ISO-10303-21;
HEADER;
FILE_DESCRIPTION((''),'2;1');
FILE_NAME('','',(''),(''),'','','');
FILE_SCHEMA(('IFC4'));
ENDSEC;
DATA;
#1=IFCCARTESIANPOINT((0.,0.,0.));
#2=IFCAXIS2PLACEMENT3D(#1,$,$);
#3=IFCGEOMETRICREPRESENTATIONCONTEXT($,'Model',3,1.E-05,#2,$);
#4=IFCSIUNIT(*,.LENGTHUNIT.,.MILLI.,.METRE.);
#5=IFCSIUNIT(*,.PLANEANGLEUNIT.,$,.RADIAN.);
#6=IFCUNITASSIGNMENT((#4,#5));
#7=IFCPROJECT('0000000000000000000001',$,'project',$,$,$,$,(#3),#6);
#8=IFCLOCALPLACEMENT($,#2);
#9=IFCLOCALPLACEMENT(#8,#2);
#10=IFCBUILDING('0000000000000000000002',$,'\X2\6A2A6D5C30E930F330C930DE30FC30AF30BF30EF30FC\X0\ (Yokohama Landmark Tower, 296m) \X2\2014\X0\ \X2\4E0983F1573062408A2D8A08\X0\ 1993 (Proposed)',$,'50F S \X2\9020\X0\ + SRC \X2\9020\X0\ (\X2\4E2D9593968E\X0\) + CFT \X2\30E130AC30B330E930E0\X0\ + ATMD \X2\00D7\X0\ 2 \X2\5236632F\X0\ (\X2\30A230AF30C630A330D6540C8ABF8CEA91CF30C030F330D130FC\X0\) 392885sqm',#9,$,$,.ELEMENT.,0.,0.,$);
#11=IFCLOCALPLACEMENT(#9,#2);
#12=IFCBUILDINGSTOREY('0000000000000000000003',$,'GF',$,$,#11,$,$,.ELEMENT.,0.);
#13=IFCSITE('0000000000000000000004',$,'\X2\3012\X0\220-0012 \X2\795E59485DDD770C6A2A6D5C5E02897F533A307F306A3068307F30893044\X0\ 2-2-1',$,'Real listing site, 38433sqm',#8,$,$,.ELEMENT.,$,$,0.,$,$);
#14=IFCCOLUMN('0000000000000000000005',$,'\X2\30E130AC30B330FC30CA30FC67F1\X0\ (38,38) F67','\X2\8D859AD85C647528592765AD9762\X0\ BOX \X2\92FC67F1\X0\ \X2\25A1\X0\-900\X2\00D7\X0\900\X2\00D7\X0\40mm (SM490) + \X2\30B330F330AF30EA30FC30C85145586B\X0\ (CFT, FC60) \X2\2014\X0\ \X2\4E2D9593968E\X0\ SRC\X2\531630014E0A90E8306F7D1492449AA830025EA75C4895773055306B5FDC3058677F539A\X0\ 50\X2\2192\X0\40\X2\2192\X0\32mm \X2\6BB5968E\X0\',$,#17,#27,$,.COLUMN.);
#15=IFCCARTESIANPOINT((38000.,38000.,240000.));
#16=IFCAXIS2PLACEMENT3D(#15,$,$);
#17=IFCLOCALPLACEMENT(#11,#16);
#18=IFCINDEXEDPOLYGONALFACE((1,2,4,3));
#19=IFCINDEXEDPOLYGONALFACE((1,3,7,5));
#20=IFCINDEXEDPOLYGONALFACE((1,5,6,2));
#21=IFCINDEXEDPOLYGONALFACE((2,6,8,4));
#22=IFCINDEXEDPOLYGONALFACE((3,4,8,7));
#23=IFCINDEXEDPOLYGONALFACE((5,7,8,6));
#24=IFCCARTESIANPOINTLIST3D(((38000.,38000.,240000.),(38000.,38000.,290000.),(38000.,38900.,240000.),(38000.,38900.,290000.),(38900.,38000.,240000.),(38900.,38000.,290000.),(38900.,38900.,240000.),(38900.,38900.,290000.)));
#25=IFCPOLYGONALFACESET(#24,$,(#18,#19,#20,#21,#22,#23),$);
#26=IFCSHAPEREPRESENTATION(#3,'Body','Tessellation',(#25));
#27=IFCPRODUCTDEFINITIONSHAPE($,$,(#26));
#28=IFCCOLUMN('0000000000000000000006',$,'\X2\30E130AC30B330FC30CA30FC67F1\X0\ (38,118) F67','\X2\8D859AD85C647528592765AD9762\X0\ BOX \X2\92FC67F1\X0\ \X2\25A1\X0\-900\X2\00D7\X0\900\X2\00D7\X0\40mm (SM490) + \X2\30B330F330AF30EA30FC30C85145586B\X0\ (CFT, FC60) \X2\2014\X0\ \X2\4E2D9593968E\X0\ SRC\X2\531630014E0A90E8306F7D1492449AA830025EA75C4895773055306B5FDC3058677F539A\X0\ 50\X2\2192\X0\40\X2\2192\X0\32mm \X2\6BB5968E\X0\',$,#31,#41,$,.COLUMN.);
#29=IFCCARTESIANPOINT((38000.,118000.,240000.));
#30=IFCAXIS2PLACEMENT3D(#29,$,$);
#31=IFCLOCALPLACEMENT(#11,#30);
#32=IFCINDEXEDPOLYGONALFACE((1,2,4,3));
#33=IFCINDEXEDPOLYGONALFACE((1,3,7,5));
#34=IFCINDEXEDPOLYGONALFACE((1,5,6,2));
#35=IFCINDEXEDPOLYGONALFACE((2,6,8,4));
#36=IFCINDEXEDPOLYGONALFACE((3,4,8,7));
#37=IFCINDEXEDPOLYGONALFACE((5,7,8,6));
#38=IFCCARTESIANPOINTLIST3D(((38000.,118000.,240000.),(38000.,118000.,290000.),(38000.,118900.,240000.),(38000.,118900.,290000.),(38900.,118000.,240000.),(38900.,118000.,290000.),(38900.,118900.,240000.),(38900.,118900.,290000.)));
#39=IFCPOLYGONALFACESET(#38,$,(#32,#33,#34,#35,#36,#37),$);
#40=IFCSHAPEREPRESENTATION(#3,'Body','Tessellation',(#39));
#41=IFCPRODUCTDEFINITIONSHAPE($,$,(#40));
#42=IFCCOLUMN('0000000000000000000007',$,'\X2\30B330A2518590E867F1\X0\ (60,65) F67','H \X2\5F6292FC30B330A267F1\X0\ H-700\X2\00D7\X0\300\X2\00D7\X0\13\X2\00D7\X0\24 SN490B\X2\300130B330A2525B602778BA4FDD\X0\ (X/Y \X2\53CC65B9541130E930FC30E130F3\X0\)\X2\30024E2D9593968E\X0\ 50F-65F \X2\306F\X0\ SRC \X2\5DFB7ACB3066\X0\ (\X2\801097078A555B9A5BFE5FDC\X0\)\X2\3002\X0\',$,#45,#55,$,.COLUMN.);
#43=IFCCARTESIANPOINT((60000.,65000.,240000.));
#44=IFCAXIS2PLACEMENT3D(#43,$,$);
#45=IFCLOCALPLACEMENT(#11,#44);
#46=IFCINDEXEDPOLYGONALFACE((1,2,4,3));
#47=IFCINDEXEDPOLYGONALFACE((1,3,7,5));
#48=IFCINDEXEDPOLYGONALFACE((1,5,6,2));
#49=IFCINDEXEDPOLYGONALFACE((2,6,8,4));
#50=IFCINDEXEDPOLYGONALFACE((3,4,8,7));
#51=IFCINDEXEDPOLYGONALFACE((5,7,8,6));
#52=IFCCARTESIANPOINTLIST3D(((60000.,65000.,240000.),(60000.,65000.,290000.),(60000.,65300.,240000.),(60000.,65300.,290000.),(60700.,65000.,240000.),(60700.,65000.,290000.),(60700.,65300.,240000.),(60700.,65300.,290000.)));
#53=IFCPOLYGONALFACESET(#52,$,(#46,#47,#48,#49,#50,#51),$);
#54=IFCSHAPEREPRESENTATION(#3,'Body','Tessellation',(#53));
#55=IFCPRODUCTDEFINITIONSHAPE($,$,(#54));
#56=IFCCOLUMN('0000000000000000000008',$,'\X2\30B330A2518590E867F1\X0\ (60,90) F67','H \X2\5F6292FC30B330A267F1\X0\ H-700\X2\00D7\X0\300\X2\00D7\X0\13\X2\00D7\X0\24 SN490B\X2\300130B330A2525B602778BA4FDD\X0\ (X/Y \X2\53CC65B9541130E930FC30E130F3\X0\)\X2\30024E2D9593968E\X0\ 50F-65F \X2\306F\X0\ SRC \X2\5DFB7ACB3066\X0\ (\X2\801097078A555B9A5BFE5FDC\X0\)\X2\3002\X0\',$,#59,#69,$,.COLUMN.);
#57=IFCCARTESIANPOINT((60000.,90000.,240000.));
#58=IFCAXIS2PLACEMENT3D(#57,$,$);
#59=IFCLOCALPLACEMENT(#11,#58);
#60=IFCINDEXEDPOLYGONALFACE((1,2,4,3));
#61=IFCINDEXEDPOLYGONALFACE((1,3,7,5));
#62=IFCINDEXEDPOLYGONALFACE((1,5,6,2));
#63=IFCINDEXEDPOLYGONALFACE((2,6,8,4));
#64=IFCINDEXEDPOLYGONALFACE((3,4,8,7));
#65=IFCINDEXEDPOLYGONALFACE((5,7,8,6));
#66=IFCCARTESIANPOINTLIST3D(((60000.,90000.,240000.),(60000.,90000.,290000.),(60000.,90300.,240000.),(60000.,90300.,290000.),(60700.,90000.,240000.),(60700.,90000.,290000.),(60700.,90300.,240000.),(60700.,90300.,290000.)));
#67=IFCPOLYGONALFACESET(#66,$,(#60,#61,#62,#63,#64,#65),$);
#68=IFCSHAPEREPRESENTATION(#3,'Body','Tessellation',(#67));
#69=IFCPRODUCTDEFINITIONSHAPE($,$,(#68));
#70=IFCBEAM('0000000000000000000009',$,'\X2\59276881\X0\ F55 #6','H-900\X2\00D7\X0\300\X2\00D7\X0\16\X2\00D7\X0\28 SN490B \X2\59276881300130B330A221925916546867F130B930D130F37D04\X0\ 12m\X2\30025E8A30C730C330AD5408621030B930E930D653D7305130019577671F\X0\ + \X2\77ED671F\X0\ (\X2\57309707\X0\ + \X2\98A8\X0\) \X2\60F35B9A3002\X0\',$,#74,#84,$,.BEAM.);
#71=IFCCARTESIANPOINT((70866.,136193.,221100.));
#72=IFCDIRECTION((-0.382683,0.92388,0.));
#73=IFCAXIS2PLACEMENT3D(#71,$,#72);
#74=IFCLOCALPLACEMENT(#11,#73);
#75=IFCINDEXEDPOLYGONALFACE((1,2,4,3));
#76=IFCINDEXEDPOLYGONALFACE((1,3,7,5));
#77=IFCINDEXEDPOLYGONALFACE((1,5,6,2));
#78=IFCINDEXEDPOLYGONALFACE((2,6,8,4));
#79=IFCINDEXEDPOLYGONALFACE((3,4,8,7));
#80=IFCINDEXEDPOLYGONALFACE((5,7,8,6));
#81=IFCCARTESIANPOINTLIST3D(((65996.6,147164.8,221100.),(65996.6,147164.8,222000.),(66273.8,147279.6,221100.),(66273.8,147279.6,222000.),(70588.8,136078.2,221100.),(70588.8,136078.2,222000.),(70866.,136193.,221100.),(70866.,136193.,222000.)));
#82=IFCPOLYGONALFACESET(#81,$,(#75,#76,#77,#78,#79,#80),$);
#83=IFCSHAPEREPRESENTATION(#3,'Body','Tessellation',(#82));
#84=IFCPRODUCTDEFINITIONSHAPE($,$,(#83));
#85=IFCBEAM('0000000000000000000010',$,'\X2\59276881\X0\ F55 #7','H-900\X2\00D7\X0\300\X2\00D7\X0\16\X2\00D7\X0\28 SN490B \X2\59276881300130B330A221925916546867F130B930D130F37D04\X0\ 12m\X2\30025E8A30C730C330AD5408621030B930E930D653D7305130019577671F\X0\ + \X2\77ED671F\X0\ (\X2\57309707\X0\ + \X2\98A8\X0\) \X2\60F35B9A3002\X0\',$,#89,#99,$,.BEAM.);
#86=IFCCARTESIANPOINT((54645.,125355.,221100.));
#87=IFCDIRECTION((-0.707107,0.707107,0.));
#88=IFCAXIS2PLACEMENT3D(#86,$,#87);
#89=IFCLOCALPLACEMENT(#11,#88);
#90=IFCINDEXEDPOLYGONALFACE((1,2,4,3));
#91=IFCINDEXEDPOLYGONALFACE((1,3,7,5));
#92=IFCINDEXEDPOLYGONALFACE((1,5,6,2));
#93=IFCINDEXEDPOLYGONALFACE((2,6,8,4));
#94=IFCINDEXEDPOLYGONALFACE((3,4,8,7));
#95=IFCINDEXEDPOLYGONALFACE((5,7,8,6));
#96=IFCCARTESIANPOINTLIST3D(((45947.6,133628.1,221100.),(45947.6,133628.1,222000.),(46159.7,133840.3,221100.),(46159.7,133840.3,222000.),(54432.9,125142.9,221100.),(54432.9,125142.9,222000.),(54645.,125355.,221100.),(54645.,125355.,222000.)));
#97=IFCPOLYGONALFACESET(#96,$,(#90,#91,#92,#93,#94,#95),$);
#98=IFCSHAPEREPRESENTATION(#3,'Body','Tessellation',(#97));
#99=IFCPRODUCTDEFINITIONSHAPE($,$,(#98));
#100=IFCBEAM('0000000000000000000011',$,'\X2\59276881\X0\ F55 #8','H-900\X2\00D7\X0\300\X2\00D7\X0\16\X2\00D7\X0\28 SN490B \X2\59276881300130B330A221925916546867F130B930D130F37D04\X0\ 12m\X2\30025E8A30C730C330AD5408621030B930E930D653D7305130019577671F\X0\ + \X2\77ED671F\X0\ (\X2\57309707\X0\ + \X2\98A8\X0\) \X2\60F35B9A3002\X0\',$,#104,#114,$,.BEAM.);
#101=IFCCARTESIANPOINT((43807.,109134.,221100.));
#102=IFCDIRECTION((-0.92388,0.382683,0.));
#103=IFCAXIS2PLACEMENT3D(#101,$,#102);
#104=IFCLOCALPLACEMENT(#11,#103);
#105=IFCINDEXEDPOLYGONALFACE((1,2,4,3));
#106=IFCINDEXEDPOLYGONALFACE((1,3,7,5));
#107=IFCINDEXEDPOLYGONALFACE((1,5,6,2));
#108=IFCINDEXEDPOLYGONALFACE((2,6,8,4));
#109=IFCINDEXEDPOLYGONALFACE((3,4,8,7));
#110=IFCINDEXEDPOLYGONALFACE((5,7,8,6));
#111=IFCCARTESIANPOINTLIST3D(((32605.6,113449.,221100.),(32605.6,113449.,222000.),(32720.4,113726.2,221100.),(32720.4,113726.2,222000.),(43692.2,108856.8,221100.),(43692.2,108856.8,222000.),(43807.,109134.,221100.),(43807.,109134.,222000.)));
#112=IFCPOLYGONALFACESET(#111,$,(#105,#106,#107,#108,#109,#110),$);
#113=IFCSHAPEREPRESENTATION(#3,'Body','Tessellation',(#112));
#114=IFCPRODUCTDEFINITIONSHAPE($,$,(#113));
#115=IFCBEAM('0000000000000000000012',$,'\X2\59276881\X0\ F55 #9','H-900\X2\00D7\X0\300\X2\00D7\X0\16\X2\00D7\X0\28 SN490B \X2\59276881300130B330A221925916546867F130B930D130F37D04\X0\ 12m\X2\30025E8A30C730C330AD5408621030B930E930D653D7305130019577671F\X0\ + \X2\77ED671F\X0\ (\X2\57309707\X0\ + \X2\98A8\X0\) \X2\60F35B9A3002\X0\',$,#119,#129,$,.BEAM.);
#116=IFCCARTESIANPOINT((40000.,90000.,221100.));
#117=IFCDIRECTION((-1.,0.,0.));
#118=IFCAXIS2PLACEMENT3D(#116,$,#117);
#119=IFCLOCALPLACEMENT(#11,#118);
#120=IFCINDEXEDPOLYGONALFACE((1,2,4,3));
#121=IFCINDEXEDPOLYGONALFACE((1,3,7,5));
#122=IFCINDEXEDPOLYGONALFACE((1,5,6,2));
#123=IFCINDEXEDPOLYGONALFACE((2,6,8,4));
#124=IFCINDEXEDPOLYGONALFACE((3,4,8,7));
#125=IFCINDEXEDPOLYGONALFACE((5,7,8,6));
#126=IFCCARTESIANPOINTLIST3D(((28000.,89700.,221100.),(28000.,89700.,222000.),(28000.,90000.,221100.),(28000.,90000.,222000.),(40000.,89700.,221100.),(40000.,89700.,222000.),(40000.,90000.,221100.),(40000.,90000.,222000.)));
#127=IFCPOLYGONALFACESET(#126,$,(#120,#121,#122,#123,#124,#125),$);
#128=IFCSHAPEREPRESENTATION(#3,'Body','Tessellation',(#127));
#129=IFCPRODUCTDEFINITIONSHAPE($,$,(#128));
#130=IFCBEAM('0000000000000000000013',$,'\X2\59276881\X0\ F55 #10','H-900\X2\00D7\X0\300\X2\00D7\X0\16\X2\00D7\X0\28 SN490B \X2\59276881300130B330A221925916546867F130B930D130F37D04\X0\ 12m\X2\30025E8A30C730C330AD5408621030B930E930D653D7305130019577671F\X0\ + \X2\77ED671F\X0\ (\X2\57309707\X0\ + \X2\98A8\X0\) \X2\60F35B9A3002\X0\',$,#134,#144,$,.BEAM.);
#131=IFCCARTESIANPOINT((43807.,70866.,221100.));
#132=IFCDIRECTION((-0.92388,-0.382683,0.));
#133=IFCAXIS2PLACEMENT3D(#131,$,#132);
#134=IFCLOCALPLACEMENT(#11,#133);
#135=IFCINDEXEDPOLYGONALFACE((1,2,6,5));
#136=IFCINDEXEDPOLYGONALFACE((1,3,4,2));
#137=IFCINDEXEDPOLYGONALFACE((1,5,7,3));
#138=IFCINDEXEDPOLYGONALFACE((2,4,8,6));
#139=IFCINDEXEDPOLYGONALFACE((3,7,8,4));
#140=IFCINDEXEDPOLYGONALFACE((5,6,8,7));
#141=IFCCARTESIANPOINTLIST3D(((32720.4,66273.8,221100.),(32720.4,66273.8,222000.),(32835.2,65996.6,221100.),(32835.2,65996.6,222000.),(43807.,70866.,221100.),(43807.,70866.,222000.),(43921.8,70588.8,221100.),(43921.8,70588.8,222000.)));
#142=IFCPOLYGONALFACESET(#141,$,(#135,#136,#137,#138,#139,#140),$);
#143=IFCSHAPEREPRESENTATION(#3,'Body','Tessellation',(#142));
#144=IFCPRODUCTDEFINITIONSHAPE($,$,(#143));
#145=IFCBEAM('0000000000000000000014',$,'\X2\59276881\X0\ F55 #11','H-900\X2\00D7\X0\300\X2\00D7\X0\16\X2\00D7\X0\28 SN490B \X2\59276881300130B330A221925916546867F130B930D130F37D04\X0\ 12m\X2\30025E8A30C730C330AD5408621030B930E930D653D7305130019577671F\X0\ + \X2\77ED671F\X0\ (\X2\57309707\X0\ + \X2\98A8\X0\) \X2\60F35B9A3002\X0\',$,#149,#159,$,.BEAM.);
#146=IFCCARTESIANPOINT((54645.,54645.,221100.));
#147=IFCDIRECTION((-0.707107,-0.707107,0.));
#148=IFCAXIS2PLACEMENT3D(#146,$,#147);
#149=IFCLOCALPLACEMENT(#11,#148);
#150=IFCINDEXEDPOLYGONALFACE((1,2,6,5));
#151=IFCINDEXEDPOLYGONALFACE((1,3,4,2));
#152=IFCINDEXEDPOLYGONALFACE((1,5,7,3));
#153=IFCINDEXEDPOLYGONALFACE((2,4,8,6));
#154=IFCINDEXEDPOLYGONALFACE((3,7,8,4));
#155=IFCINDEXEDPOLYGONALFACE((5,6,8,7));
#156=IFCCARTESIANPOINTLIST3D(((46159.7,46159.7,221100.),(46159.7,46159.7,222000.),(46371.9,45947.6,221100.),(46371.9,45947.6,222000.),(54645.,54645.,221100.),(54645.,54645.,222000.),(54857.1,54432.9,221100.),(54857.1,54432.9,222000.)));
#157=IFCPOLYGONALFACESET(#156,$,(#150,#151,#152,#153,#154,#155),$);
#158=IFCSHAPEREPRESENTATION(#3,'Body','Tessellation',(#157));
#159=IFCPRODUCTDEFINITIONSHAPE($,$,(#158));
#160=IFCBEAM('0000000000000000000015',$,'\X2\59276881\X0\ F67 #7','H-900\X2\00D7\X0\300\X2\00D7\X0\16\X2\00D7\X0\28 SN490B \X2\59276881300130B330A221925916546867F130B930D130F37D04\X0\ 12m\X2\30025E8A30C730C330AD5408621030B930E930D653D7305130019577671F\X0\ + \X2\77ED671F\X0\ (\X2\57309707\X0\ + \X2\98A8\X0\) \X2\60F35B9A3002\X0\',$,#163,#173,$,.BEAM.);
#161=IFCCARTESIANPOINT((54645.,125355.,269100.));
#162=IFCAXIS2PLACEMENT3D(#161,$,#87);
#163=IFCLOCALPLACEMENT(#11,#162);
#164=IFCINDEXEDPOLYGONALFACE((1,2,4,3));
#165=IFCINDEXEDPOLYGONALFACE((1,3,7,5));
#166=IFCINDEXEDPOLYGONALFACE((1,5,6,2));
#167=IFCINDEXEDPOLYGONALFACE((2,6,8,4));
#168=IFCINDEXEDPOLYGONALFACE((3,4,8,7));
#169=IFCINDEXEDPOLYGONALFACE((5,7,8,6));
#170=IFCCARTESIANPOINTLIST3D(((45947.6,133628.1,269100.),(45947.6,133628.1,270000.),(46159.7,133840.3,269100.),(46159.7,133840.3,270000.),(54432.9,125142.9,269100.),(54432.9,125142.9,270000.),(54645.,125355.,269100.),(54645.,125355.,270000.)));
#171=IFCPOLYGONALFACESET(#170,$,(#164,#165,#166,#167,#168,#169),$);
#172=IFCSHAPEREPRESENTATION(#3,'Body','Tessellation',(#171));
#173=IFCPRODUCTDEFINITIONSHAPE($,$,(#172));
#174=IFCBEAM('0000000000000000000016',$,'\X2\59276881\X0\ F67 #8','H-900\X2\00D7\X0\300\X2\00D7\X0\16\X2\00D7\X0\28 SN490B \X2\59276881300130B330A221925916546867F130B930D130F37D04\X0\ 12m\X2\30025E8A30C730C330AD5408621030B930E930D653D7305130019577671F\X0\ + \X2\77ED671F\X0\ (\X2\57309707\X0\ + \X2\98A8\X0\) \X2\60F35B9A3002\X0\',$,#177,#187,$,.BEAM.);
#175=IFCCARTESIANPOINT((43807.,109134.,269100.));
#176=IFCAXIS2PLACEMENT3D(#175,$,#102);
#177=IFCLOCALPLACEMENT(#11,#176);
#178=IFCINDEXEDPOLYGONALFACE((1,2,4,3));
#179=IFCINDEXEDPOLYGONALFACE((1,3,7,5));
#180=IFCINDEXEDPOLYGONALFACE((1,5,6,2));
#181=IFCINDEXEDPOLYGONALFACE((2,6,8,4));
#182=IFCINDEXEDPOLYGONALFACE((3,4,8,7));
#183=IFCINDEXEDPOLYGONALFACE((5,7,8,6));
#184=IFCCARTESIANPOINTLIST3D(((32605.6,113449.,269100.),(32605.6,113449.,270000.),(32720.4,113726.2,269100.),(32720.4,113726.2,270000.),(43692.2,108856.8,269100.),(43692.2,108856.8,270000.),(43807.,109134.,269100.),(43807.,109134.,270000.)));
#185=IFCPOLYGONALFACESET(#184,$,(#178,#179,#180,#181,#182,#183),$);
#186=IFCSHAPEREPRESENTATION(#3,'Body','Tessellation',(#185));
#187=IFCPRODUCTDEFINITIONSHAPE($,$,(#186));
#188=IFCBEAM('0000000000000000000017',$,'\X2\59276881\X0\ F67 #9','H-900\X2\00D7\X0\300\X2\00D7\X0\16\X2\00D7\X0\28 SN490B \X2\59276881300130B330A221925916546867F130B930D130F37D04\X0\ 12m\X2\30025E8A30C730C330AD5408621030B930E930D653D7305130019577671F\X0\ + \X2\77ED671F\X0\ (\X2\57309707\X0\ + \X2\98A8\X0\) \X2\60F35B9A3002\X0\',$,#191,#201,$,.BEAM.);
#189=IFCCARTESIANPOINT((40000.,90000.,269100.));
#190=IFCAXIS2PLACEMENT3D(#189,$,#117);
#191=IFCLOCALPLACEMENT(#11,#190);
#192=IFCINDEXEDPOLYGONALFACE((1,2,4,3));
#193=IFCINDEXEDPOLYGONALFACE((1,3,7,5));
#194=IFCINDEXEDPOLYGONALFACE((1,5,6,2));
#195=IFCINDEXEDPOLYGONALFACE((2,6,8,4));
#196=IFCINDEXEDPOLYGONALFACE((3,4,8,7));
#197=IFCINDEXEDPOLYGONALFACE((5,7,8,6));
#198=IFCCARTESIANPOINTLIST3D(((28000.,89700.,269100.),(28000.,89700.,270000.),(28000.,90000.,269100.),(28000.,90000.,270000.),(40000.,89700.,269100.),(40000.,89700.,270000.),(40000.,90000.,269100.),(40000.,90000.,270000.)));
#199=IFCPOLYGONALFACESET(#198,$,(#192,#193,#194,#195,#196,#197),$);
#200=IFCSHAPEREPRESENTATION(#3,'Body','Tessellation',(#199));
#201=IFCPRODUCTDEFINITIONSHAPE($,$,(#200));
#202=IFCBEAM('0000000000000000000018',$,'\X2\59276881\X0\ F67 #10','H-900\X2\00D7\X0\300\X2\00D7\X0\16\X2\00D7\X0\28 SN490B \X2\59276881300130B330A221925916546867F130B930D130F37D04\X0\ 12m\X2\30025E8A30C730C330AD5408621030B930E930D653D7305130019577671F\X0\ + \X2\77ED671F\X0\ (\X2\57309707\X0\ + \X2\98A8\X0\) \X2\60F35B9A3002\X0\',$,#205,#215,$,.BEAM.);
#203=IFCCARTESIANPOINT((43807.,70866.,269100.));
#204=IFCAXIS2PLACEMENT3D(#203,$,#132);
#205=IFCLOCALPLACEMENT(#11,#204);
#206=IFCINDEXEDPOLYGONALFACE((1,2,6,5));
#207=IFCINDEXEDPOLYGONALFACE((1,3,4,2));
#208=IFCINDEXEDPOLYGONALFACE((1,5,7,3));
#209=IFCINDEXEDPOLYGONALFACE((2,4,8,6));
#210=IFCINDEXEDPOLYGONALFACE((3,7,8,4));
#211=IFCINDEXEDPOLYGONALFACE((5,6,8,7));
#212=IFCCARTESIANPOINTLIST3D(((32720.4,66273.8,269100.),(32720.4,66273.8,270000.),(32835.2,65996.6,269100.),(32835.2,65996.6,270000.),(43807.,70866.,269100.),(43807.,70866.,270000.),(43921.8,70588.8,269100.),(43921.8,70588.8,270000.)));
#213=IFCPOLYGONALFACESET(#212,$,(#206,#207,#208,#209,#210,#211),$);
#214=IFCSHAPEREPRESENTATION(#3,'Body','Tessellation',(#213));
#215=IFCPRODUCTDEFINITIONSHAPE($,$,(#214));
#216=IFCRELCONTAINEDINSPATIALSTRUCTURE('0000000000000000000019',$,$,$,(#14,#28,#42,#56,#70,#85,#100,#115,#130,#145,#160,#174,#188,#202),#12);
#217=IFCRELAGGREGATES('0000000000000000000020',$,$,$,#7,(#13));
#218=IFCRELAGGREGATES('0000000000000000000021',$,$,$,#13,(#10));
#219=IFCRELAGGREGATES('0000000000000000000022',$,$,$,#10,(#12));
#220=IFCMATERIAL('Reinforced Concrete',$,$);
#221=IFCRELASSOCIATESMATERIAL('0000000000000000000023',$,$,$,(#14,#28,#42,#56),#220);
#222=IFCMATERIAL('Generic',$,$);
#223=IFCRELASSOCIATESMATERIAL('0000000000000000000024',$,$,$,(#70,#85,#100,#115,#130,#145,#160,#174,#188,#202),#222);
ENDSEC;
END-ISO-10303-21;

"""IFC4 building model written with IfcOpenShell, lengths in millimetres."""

from ifc_helpers import new_model, si_unit, frame, frame_2d, origin, place, context, project, spatial, rectangle, extrude, material, element, save


model = new_model("IFC4")

# Units and contexts
model_context = context("Model", 3, precision=1e-05, world=origin())
ifc_project = project(units=[si_unit("LENGTHUNIT", "METRE", prefix="MILLI"), si_unit("PLANEANGLEUNIT", "RADIAN")], contexts=[model_context])

# Site, building, storey
site_placement = place(None, origin())
site = spatial("IfcSite", under=ifc_project, at=site_placement, Name="〒220-0012 神奈川県横浜市西区みなとみらい 2-2-1", ObjectType="Real listing site, 38433sqm", CompositionType="ELEMENT", RefElevation=0.0)
building_placement = place(site_placement, origin())
building = spatial("IfcBuilding", under=site, at=building_placement, Name="横浜ランドマークタワー (Yokohama Landmark Tower, 296m) — 三菱地所設計 1993 (Proposed)", ObjectType="50F S 造 + SRC 造 (中間階) + CFT メガコラム + ATMD × 2 制振 (アクティブ同調質量ダンパー) 392885sqm", CompositionType="ELEMENT", ElevationOfRefHeight=0.0, ElevationOfTerrain=0.0)
storey_placement = place(building_placement, origin())
storey = spatial("IfcBuildingStorey", under=building, at=storey_placement, Name="GF", CompositionType="ELEMENT", Elevation=0.0)

# Columns
ifc_material_1 = material(Name="Reinforced Concrete")
column_1_placement = place(storey_placement, frame((38000.0, 38000.0, 240000.0)))
element("IfcColumn", 1, at=column_1_placement, inside=storey, material=ifc_material_1, Name="メガコーナー柱 (38,38) F67", Description="超高層用大断面 BOX 鋼柱 □-900×900×40mm (SM490) + コンクリート充填 (CFT, FC60) — 中間階 SRC化、上部は純鉄骨。座屈長さに応じ板厚 50→40→32mm 段階", PredefinedType="COLUMN", context=model_context, shape_type="SweptSolid", body=[
    extrude(rectangle(XDim=900.0, YDim=900.0, at=frame_2d((450.0, 450.0))), frame((38000.0, 38000.0, 240000.0)), (0.0, 0.0, 1.0), 50000.0),
])
column_2_placement = place(storey_placement, frame((38000.0, 118000.0, 240000.0)))
element("IfcColumn", 2, at=column_2_placement, inside=storey, material=ifc_material_1, Name="メガコーナー柱 (38,118) F67", Description="超高層用大断面 BOX 鋼柱 □-900×900×40mm (SM490) + コンクリート充填 (CFT, FC60) — 中間階 SRC化、上部は純鉄骨。座屈長さに応じ板厚 50→40→32mm 段階", PredefinedType="COLUMN", context=model_context, shape_type="SweptSolid", body=[
    extrude(rectangle(XDim=900.0, YDim=900.0, at=frame_2d((450.0, 450.0))), frame((38000.0, 118000.0, 240000.0)), (0.0, 0.0, 1.0), 50000.0),
])
column_3_placement = place(storey_placement, frame((60000.0, 65000.0, 240000.0)))
element("IfcColumn", 3, at=column_3_placement, inside=storey, material=ifc_material_1, Name="コア内部柱 (60,65) F67", Description="H 形鋼コア柱 H-700×300×13×24 SN490B、コア剛性確保 (X/Y 双方向ラーメン)。中間階 50F-65F は SRC 巻立て (耐震評定対応)。", PredefinedType="COLUMN", context=model_context, shape_type="SweptSolid", body=[
    extrude(rectangle(XDim=700.0, YDim=300.0, at=frame_2d((350.0, 150.0))), frame((60000.0, 65000.0, 240000.0)), (0.0, 0.0, 1.0), 50000.0),
])
column_4_placement = place(storey_placement, frame((60000.0, 90000.0, 240000.0)))
element("IfcColumn", 4, at=column_4_placement, inside=storey, material=ifc_material_1, Name="コア内部柱 (60,90) F67", Description="H 形鋼コア柱 H-700×300×13×24 SN490B、コア剛性確保 (X/Y 双方向ラーメン)。中間階 50F-65F は SRC 巻立て (耐震評定対応)。", PredefinedType="COLUMN", context=model_context, shape_type="SweptSolid", body=[
    extrude(rectangle(XDim=700.0, YDim=300.0, at=frame_2d((350.0, 150.0))), frame((60000.0, 90000.0, 240000.0)), (0.0, 0.0, 1.0), 50000.0),
])

# Beams
ifc_material_2 = material(Name="Generic")
beam_1_placement = place(storey_placement, frame((70866.0, 136193.0, 221100.0), x_axis=(-0.382683, 0.92388, 0.0)))
element("IfcBeam", 5, at=beam_1_placement, inside=storey, material=ifc_material_2, Name="大梁 F55 #6", Description="H-900×300×16×28 SN490B 大梁、コア→外周柱スパン約 12m。床デッキ合成スラブ受け、長期 + 短期 (地震 + 風) 想定。", PredefinedType="BEAM", context=model_context, shape_type="SweptSolid", body=[
    extrude(rectangle(XDim=12000.0, YDim=300.0, at=frame_2d((6000.0, 150.0))), frame((70866.0, 136193.0, 221100.0), x_axis=(-0.382683, 0.92388, 0.0)), (0.0, 0.0, 1.0), 900.0),
])
beam_2_placement = place(storey_placement, frame((54645.0, 125355.0, 221100.0), x_axis=(-0.707107, 0.707107, 0.0)))
element("IfcBeam", 6, at=beam_2_placement, inside=storey, material=ifc_material_2, Name="大梁 F55 #7", Description="H-900×300×16×28 SN490B 大梁、コア→外周柱スパン約 12m。床デッキ合成スラブ受け、長期 + 短期 (地震 + 風) 想定。", PredefinedType="BEAM", context=model_context, shape_type="SweptSolid", body=[
    extrude(rectangle(XDim=12000.0, YDim=300.0, at=frame_2d((6000.0, 150.0))), frame((54645.0, 125355.0, 221100.0), x_axis=(-0.707107, 0.707107, 0.0)), (0.0, 0.0, 1.0), 900.0),
])
beam_3_placement = place(storey_placement, frame((43807.0, 109134.0, 221100.0), x_axis=(-0.92388, 0.382683, 0.0)))
element("IfcBeam", 7, at=beam_3_placement, inside=storey, material=ifc_material_2, Name="大梁 F55 #8", Description="H-900×300×16×28 SN490B 大梁、コア→外周柱スパン約 12m。床デッキ合成スラブ受け、長期 + 短期 (地震 + 風) 想定。", PredefinedType="BEAM", context=model_context, shape_type="SweptSolid", body=[
    extrude(rectangle(XDim=12000.0, YDim=300.0, at=frame_2d((6000.0, 150.0))), frame((43807.0, 109134.0, 221100.0), x_axis=(-0.92388, 0.382683, 0.0)), (0.0, 0.0, 1.0), 900.0),
])
beam_4_placement = place(storey_placement, frame((40000.0, 90000.0, 221100.0), x_axis=(-1.0, 0.0, 0.0)))
element("IfcBeam", 8, at=beam_4_placement, inside=storey, material=ifc_material_2, Name="大梁 F55 #9", Description="H-900×300×16×28 SN490B 大梁、コア→外周柱スパン約 12m。床デッキ合成スラブ受け、長期 + 短期 (地震 + 風) 想定。", PredefinedType="BEAM", context=model_context, shape_type="SweptSolid", body=[
    extrude(rectangle(XDim=12000.0, YDim=300.0, at=frame_2d((6000.0, 150.0))), frame((40000.0, 90000.0, 221100.0), x_axis=(-1.0, 0.0, 0.0)), (0.0, 0.0, 1.0), 900.0),
])
beam_5_placement = place(storey_placement, frame((43807.0, 70866.0, 221100.0), x_axis=(-0.92388, -0.382683, 0.0)))
element("IfcBeam", 9, at=beam_5_placement, inside=storey, material=ifc_material_2, Name="大梁 F55 #10", Description="H-900×300×16×28 SN490B 大梁、コア→外周柱スパン約 12m。床デッキ合成スラブ受け、長期 + 短期 (地震 + 風) 想定。", PredefinedType="BEAM", context=model_context, shape_type="SweptSolid", body=[
    extrude(rectangle(XDim=12000.0, YDim=300.0, at=frame_2d((6000.0, 150.0))), frame((43807.0, 70866.0, 221100.0), x_axis=(-0.92388, -0.382683, 0.0)), (0.0, 0.0, 1.0), 900.0),
])
beam_6_placement = place(storey_placement, frame((54645.0, 54645.0, 221100.0), x_axis=(-0.707107, -0.707107, 0.0)))
element("IfcBeam", 10, at=beam_6_placement, inside=storey, material=ifc_material_2, Name="大梁 F55 #11", Description="H-900×300×16×28 SN490B 大梁、コア→外周柱スパン約 12m。床デッキ合成スラブ受け、長期 + 短期 (地震 + 風) 想定。", PredefinedType="BEAM", context=model_context, shape_type="SweptSolid", body=[
    extrude(rectangle(XDim=12000.0, YDim=300.0, at=frame_2d((6000.0, 150.0))), frame((54645.0, 54645.0, 221100.0), x_axis=(-0.707107, -0.707107, 0.0)), (0.0, 0.0, 1.0), 900.0),
])
beam_7_placement = place(storey_placement, frame((54645.0, 125355.0, 269100.0), x_axis=(-0.707107, 0.707107, 0.0)))
element("IfcBeam", 11, at=beam_7_placement, inside=storey, material=ifc_material_2, Name="大梁 F67 #7", Description="H-900×300×16×28 SN490B 大梁、コア→外周柱スパン約 12m。床デッキ合成スラブ受け、長期 + 短期 (地震 + 風) 想定。", PredefinedType="BEAM", context=model_context, shape_type="SweptSolid", body=[
    extrude(rectangle(XDim=12000.0, YDim=300.0, at=frame_2d((6000.0, 150.0))), frame((54645.0, 125355.0, 269100.0), x_axis=(-0.707107, 0.707107, 0.0)), (0.0, 0.0, 1.0), 900.0),
])
beam_8_placement = place(storey_placement, frame((43807.0, 109134.0, 269100.0), x_axis=(-0.92388, 0.382683, 0.0)))
element("IfcBeam", 12, at=beam_8_placement, inside=storey, material=ifc_material_2, Name="大梁 F67 #8", Description="H-900×300×16×28 SN490B 大梁、コア→外周柱スパン約 12m。床デッキ合成スラブ受け、長期 + 短期 (地震 + 風) 想定。", PredefinedType="BEAM", context=model_context, shape_type="SweptSolid", body=[
    extrude(rectangle(XDim=12000.0, YDim=300.0, at=frame_2d((6000.0, 150.0))), frame((43807.0, 109134.0, 269100.0), x_axis=(-0.92388, 0.382683, 0.0)), (0.0, 0.0, 1.0), 900.0),
])
beam_9_placement = place(storey_placement, frame((40000.0, 90000.0, 269100.0), x_axis=(-1.0, 0.0, 0.0)))
element("IfcBeam", 13, at=beam_9_placement, inside=storey, material=ifc_material_2, Name="大梁 F67 #9", Description="H-900×300×16×28 SN490B 大梁、コア→外周柱スパン約 12m。床デッキ合成スラブ受け、長期 + 短期 (地震 + 風) 想定。", PredefinedType="BEAM", context=model_context, shape_type="SweptSolid", body=[
    extrude(rectangle(XDim=12000.0, YDim=300.0, at=frame_2d((6000.0, 150.0))), frame((40000.0, 90000.0, 269100.0), x_axis=(-1.0, 0.0, 0.0)), (0.0, 0.0, 1.0), 900.0),
])
beam_10_placement = place(storey_placement, frame((43807.0, 70866.0, 269100.0), x_axis=(-0.92388, -0.382683, 0.0)))
element("IfcBeam", 14, at=beam_10_placement, inside=storey, material=ifc_material_2, Name="大梁 F67 #10", Description="H-900×300×16×28 SN490B 大梁、コア→外周柱スパン約 12m。床デッキ合成スラブ受け、長期 + 短期 (地震 + 風) 想定。", PredefinedType="BEAM", context=model_context, shape_type="SweptSolid", body=[
    extrude(rectangle(XDim=12000.0, YDim=300.0, at=frame_2d((6000.0, 150.0))), frame((43807.0, 70866.0, 269100.0), x_axis=(-0.92388, -0.382683, 0.0)), (0.0, 0.0, 1.0), 900.0),
])

save(model, "model.ifc")
